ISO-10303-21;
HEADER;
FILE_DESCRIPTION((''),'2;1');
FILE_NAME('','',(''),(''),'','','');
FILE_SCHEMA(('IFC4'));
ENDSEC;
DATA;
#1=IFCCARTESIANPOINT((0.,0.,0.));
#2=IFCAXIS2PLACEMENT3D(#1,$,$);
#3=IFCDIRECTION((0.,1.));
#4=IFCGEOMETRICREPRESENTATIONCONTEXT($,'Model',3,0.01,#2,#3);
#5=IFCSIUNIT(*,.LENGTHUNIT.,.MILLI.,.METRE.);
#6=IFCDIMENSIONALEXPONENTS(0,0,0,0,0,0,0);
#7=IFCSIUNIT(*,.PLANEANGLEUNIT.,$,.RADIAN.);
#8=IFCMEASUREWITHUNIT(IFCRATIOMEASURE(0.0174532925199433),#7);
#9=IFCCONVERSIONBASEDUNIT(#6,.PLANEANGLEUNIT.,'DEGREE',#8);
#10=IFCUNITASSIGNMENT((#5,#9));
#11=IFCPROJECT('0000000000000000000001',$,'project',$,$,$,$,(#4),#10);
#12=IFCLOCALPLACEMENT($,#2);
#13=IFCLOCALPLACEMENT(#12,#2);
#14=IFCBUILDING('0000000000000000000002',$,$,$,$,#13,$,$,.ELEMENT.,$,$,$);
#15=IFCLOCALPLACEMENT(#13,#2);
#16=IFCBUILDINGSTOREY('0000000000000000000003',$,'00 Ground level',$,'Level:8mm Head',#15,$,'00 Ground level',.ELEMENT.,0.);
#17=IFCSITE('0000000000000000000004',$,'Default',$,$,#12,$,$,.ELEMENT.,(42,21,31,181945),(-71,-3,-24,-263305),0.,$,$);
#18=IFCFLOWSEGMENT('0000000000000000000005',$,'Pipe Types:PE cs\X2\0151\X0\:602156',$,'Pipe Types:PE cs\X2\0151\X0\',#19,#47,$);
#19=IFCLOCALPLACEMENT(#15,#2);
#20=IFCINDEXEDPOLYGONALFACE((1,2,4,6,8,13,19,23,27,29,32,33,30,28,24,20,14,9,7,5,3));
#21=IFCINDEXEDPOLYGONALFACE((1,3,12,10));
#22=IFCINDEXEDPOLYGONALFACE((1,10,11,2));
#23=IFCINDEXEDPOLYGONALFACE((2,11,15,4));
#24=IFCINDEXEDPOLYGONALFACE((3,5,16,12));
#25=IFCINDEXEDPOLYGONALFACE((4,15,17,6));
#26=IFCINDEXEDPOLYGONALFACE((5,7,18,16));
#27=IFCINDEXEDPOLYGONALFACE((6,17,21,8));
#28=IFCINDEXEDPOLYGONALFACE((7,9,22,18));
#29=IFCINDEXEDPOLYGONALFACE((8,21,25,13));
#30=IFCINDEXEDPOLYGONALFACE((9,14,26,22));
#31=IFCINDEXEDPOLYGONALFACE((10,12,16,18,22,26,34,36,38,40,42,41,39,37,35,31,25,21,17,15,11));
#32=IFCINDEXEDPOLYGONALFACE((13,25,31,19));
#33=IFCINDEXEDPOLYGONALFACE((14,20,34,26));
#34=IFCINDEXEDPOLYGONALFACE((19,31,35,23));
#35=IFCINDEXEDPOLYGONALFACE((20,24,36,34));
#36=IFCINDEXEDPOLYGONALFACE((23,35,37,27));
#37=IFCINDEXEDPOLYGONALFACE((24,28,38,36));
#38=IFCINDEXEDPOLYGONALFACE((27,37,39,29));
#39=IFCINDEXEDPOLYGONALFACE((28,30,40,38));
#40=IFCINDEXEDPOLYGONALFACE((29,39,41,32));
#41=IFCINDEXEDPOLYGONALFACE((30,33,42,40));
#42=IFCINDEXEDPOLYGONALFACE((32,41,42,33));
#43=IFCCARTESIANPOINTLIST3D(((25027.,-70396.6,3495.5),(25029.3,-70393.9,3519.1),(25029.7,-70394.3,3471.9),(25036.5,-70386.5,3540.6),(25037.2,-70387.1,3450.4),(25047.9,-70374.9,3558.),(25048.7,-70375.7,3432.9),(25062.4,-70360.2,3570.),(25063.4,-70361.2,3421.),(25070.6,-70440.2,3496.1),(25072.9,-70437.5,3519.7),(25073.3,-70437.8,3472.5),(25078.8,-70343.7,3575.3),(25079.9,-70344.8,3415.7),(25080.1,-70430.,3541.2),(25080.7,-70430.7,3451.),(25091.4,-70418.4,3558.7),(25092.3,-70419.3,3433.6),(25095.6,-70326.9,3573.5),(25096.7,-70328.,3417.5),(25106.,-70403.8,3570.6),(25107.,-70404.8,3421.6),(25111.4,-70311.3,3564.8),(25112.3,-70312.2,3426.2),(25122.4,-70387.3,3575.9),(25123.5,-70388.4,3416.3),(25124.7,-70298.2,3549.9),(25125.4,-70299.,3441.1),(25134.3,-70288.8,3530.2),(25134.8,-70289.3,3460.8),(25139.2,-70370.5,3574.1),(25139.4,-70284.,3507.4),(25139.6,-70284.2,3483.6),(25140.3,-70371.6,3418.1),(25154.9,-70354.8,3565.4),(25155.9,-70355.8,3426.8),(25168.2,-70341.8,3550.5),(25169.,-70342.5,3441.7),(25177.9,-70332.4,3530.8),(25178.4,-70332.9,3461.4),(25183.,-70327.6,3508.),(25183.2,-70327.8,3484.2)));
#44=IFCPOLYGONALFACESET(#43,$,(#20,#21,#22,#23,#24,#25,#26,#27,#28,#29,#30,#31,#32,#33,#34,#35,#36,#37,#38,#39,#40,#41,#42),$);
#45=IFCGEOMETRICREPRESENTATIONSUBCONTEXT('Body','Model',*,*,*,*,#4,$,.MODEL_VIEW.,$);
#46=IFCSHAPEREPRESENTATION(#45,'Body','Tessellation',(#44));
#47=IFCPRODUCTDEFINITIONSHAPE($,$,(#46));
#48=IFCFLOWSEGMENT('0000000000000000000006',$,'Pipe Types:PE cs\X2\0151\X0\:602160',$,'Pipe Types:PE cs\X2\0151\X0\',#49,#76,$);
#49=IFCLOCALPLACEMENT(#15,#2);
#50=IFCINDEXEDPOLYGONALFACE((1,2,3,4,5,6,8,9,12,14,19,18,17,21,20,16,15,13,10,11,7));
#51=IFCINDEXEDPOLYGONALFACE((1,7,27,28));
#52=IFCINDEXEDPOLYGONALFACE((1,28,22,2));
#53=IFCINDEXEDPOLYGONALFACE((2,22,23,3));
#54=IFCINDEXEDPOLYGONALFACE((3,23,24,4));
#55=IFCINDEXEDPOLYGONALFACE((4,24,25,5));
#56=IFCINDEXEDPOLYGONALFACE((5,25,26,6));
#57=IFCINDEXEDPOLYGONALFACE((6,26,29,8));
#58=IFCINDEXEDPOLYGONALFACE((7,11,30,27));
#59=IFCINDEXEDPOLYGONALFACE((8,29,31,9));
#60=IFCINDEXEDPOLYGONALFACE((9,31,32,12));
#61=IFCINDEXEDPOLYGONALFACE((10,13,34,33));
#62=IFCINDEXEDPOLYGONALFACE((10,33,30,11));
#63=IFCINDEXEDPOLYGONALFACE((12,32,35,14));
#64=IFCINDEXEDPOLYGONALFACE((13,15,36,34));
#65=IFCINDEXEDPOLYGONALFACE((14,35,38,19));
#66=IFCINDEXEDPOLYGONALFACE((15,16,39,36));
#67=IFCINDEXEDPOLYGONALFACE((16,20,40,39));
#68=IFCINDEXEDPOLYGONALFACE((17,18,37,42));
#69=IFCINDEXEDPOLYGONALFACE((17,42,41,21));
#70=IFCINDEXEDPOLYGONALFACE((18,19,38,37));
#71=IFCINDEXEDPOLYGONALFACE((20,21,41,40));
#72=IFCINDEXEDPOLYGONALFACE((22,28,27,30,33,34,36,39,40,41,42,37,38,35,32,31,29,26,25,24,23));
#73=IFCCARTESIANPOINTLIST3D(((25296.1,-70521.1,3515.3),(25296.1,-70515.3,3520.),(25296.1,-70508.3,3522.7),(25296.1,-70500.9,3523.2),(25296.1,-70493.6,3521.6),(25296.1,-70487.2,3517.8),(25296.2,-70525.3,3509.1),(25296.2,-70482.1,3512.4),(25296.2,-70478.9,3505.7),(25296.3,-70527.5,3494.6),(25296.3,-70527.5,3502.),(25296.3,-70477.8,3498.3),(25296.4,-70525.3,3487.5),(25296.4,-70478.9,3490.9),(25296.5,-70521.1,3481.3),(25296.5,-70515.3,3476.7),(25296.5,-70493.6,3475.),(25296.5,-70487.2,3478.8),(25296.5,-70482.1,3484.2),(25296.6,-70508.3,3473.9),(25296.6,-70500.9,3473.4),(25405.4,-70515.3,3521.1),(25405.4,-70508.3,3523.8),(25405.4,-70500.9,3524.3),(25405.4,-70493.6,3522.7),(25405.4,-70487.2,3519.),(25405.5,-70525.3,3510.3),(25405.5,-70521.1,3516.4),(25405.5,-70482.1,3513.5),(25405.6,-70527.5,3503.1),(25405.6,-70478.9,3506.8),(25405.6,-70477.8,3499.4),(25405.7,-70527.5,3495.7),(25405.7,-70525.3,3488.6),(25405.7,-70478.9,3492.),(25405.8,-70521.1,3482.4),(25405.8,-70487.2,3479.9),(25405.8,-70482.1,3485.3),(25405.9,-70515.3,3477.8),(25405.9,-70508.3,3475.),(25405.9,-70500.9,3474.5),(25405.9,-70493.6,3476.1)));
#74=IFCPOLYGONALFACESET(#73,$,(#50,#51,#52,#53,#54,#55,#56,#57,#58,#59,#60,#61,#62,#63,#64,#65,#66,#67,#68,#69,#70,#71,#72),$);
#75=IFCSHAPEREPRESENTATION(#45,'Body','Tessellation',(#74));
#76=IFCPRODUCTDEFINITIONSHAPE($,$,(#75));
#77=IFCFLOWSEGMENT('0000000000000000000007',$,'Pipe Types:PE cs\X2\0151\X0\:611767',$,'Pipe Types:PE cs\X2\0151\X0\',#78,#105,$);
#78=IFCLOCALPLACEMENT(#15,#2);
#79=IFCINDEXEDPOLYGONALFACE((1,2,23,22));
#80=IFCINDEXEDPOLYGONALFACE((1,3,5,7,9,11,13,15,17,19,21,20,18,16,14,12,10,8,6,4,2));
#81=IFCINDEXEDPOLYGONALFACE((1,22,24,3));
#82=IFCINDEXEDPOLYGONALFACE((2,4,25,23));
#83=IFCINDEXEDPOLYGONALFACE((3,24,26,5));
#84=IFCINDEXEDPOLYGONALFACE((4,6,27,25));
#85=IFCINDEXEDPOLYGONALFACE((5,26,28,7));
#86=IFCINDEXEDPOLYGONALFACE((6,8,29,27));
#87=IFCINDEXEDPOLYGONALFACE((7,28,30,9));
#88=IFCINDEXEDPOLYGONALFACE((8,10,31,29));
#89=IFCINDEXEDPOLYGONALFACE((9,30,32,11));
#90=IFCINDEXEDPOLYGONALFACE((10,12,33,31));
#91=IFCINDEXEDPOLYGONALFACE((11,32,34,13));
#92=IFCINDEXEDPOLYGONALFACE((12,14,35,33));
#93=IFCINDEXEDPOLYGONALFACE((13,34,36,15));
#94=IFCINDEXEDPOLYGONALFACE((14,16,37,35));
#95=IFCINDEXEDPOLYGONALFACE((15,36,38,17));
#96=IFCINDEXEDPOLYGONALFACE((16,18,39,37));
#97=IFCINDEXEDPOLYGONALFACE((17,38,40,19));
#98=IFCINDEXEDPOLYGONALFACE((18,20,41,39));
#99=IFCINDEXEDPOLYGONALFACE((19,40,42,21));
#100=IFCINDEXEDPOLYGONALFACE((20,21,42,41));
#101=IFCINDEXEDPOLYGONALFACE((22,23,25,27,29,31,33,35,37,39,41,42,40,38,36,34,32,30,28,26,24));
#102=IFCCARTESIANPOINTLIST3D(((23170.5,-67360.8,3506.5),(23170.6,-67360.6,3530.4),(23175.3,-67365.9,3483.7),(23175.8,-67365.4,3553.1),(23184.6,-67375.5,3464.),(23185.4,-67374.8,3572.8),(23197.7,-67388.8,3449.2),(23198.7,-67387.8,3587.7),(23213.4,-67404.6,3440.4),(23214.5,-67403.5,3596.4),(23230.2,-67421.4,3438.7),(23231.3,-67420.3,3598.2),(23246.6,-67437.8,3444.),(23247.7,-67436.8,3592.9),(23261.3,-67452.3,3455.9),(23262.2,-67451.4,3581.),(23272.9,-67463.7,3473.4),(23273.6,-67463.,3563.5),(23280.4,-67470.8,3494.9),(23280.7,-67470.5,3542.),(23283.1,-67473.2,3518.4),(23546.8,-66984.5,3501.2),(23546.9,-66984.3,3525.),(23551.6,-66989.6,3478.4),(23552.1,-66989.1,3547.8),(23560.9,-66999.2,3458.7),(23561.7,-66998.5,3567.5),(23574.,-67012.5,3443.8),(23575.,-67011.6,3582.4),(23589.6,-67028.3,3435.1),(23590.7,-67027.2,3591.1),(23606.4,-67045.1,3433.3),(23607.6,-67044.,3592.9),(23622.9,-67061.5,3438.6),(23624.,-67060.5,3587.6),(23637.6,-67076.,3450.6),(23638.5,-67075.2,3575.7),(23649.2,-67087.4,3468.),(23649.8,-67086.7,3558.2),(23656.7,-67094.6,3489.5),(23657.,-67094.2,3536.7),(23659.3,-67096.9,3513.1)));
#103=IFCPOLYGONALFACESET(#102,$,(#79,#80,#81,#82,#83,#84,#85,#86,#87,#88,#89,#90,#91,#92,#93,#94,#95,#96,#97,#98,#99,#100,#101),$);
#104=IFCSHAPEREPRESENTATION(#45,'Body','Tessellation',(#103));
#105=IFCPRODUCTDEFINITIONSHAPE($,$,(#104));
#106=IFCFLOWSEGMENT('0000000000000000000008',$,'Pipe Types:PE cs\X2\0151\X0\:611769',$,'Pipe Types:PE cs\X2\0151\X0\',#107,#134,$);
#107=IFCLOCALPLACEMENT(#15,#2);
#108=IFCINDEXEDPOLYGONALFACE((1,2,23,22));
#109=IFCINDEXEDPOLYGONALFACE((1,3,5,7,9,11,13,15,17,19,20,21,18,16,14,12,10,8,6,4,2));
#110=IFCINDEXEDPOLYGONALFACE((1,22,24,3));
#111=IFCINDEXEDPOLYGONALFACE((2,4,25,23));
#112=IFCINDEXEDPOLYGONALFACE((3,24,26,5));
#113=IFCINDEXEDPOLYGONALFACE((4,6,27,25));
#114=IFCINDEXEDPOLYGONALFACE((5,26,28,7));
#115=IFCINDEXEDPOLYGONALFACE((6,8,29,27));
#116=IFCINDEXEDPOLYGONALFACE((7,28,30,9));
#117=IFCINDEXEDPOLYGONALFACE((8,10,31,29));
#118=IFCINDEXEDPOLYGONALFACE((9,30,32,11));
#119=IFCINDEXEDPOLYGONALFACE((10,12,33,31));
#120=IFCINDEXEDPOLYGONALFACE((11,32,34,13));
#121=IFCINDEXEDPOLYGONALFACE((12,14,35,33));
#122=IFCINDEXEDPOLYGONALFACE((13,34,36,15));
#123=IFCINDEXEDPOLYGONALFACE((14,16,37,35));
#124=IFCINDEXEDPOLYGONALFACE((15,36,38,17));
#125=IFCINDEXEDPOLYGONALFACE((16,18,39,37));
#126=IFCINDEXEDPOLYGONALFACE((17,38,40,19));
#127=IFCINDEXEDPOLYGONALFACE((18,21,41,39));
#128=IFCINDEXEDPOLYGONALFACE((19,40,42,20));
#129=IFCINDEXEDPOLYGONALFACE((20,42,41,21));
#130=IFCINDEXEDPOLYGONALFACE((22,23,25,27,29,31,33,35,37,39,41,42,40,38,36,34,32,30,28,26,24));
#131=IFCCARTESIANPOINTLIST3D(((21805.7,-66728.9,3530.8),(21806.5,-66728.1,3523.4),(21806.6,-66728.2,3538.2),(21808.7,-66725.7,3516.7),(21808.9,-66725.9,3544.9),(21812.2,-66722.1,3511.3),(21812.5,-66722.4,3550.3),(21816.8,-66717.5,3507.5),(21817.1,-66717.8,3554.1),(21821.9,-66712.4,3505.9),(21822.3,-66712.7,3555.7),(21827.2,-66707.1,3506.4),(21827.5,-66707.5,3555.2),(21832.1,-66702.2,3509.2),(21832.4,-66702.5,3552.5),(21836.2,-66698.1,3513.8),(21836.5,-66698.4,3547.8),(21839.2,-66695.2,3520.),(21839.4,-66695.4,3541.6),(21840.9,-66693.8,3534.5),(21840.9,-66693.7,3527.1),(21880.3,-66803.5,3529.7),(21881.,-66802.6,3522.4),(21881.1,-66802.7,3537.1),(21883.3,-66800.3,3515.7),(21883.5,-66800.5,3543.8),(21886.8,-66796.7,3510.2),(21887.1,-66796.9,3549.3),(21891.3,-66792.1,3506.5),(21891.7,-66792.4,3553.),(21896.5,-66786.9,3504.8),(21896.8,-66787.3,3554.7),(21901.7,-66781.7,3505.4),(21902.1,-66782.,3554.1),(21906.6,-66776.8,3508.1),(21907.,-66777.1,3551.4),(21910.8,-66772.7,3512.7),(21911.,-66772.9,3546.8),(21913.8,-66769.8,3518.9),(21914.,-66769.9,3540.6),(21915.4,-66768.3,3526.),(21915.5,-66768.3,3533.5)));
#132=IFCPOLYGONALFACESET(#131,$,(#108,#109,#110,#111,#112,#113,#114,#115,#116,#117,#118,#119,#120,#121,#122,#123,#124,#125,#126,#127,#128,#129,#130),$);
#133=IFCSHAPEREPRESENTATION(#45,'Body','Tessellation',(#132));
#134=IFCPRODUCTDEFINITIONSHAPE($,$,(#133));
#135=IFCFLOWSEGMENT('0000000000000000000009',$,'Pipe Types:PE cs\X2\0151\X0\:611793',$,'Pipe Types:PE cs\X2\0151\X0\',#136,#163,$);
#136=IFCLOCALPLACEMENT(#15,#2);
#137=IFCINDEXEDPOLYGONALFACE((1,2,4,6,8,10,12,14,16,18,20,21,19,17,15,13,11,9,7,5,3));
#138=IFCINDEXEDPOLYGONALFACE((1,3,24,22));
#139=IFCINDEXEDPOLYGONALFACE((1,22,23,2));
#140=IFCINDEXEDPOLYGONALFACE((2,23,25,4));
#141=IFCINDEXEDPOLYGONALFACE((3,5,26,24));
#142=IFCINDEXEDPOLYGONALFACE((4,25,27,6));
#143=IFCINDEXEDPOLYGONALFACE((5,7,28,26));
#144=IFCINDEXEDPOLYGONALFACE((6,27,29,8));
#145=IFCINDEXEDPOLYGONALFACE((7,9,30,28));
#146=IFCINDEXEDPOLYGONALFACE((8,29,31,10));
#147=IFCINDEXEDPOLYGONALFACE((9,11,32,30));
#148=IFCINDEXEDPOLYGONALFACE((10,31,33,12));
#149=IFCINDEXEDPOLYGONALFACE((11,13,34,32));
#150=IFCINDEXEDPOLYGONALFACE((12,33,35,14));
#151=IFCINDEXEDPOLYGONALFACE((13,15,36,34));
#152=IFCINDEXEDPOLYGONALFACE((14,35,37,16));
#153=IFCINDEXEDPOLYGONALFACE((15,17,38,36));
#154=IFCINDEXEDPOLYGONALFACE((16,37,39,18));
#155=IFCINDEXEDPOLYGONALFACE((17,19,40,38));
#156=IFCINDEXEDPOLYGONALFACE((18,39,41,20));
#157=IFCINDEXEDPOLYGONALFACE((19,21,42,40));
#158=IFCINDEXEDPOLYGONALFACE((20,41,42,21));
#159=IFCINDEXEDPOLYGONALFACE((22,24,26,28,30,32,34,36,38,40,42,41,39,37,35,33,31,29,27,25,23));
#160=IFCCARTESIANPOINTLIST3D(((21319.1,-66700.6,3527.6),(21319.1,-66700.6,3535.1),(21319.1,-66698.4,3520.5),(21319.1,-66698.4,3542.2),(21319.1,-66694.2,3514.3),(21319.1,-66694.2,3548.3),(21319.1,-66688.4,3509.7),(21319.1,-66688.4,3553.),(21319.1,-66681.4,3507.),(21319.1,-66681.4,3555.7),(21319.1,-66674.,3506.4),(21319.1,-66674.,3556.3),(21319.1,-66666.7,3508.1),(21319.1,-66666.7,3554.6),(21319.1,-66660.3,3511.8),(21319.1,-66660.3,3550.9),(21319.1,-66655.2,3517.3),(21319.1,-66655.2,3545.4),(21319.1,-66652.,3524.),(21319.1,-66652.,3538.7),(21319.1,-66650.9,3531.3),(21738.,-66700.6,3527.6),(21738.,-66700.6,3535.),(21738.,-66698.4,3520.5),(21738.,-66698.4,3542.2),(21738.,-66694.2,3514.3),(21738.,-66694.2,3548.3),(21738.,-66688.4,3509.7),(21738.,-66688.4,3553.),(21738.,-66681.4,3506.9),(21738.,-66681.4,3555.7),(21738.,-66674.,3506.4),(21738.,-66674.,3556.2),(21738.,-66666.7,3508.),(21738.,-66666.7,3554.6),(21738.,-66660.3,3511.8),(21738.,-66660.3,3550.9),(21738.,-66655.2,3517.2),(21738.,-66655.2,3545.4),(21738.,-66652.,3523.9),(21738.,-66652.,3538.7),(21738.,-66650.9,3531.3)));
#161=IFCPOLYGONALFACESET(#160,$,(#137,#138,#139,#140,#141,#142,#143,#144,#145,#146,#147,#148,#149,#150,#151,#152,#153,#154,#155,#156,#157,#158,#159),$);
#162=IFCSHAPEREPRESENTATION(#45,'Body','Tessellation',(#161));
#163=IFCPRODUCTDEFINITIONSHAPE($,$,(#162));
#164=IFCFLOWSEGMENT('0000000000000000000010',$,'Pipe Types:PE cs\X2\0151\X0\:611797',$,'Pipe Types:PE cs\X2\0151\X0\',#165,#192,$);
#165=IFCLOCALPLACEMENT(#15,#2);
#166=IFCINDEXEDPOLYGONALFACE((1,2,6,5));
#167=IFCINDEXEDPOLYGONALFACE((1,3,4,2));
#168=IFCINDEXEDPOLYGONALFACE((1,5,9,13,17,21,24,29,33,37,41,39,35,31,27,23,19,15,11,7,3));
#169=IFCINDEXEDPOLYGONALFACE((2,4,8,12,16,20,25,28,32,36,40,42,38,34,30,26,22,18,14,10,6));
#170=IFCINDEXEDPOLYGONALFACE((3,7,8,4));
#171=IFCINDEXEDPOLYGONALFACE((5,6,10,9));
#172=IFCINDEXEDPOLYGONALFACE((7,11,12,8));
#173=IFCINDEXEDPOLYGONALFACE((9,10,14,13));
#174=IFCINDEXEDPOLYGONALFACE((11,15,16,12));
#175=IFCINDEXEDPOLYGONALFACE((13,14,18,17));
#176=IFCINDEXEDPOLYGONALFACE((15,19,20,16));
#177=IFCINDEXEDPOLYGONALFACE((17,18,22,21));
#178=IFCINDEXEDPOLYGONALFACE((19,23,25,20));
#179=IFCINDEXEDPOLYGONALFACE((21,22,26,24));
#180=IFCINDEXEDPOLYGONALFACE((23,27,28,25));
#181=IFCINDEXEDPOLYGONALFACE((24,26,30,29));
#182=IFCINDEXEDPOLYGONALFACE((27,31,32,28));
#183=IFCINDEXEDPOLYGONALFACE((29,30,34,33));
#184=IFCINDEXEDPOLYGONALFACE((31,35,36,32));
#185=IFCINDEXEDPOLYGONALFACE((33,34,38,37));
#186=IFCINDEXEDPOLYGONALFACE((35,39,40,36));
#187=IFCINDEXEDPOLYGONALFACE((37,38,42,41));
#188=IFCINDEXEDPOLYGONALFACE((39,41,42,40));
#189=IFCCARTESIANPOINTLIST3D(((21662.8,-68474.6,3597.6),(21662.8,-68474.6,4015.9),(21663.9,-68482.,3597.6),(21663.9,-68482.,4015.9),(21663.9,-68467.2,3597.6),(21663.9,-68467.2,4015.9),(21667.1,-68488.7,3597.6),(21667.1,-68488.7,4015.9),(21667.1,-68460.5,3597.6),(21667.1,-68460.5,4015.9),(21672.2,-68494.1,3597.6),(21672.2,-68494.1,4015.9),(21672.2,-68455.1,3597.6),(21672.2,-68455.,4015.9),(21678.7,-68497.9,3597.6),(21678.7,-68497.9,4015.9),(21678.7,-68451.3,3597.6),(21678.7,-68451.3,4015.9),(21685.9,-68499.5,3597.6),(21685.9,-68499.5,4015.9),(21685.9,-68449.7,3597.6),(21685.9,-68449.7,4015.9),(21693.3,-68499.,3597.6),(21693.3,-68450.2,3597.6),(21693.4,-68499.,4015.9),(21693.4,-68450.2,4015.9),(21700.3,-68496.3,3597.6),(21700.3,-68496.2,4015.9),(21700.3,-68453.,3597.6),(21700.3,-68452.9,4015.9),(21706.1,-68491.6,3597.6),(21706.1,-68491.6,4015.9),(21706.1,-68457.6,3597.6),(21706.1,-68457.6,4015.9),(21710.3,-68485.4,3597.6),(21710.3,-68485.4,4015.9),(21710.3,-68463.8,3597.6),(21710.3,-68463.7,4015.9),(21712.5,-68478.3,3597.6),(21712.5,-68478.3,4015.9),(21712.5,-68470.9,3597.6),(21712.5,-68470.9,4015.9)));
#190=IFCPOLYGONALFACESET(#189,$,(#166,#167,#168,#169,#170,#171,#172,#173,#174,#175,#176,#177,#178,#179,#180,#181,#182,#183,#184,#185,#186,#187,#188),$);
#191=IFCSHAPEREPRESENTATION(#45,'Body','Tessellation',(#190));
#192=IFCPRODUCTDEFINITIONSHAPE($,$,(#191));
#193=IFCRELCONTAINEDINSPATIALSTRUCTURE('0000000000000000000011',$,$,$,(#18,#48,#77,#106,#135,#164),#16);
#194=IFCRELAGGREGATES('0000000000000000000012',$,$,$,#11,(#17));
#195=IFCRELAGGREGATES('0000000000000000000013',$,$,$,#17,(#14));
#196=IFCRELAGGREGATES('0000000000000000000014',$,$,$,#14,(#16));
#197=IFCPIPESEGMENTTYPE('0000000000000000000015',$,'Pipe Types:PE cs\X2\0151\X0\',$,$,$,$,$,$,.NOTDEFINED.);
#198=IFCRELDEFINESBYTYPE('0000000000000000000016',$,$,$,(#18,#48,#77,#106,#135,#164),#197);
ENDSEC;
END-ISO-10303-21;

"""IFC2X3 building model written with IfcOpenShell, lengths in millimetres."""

from ifc_helpers import new_model, entity, si_unit, converted_unit, direction, frame, frame_2d, origin, origin_2d_with_axis, place, context, subcontext, project, spatial, circle, extrude, type_object, element, save


model = new_model("IFC2X3")

# Units and contexts
model_context = context("Model", 3, precision=0.01, world=origin(), true_north=direction((0.0, 1.0)))
body_context = subcontext(model_context, "Body", "Model", "MODEL_VIEW")
ifc_project = project(units=[si_unit("LENGTHUNIT", "METRE", prefix="MILLI"), converted_unit("PLANEANGLEUNIT", "DEGREE", entity("IfcRatioMeasure", 0.0174532925199433), si_unit("PLANEANGLEUNIT", "RADIAN"), dimensions=[0, 0, 0, 0, 0, 0, 0])], contexts=[model_context])

# Site, building, storey
site_placement = place(None, origin())
site = spatial("IfcSite", under=ifc_project, at=site_placement, Name="Default", CompositionType="ELEMENT", RefLatitude=(42, 21, 31, 181945), RefLongitude=(-71, -3, -24, -263305), RefElevation=0.0)
building_placement = place(site_placement, origin())
building = spatial("IfcBuilding", under=site, at=building_placement, CompositionType="ELEMENT")
storey_placement = place(building_placement, origin())
storey = spatial("IfcBuildingStorey", under=building, at=storey_placement, Name="00 Ground level", ObjectType="Level:8mm Head", LongName="00 Ground level", CompositionType="ELEMENT", Elevation=0.0)

# Flow segments
pipe_segment_type = type_object("IfcPipeSegmentType", Name="Pipe Types:PE cső", PredefinedType="NOTDEFINED")
flow_segment_1_placement = place(storey_placement, frame((25025.4, -70441.8, 3413.9)))
element("IfcFlowSegment", 1, at=flow_segment_1_placement, inside=storey, type_object=pipe_segment_type, Name="Pipe Types:PE cső:602156", ObjectType="Pipe Types:PE cső", context=body_context, shape_type="SweptSolid", body=[
    extrude(circle(Radius=80.0, at=origin_2d_with_axis()), frame((58.2, 101.7, 81.6), z_axis=(0.707071, -0.707071, 0.010046), x_axis=(-0.707107, -0.707107, 0.0)), (0.0, 0.0, 1.0), 61.6),
])
flow_segment_2_placement = place(storey_placement, frame((25294.5, -70529.4, 3471.7)))
element("IfcFlowSegment", 2, at=flow_segment_2_placement, inside=storey, type_object=pipe_segment_type, Name="Pipe Types:PE cső:602160", ObjectType="Pipe Types:PE cső", context=body_context, shape_type="SweptSolid", body=[
    extrude(circle(Radius=25.0, at=frame_2d((0.0, 0.0), x_axis=(1.0, 0.0))), frame((1.9, 26.6, 26.6), z_axis=(0.999948, -0.000032, 0.010203), x_axis=(0.000032, 1.0, 0.0)), (0.0, 0.0, 1.0), 109.3),
])
flow_segment_3_placement = place(storey_placement, frame((23168.3, -67474.8, 3431.5)))
element("IfcFlowSegment", 3, at=flow_segment_3_placement, inside=storey, type_object=pipe_segment_type, Name="Pipe Types:PE cső:611767", ObjectType="Pipe Types:PE cső", context=body_context, shape_type="SweptSolid", body=[
    extrude(circle(Radius=80.0, at=origin_2d_with_axis()), frame((58.2, 58.2, 86.9), z_axis=(0.707071, 0.707071, -0.01), x_axis=(0.707107, -0.707107, 0.0)), (0.0, 0.0, 1.0), 532.2),
])
flow_segment_4_placement = place(storey_placement, frame((21804.1, -66805.1, 3503.2)))
element("IfcFlowSegment", 4, at=flow_segment_4_placement, inside=storey, type_object=pipe_segment_type, Name="Pipe Types:PE cső:611769", ObjectType="Pipe Types:PE cső", context=body_context, shape_type="SweptSolid", body=[
    extrude(circle(Radius=25.0, at=frame_2d((0.0, 0.0), x_axis=(1.0, 0.0))), frame((19.3, 93.8, 27.6), z_axis=(0.707071, -0.707071, -0.01), x_axis=(-0.707107, -0.707107, 0.0)), (0.0, 0.0, 1.0), 105.5),
])
flow_segment_5_placement = place(storey_placement, frame((21319.1, -66702.5, 3504.7)))
element("IfcFlowSegment", 5, at=flow_segment_5_placement, inside=storey, type_object=pipe_segment_type, Name="Pipe Types:PE cső:611793", ObjectType="Pipe Types:PE cső", context=body_context, shape_type="SweptSolid", body=[
    extrude(circle(Radius=25.0, at=origin_2d_with_axis()), frame((0.0, 26.6, 26.6), z_axis=(1.0, 0.0, -0.000085), x_axis=(0.0, 1.0, 0.0)), (0.0, 0.0, 1.0), 418.9),
])
flow_segment_6_placement = place(storey_placement, frame((21661.2, -68501.2, 3597.6)))
element("IfcFlowSegment", 6, at=flow_segment_6_placement, inside=storey, type_object=pipe_segment_type, Name="Pipe Types:PE cső:611797", ObjectType="Pipe Types:PE cső", context=body_context, shape_type="SweptSolid", body=[
    extrude(circle(Radius=25.0, at=frame_2d((0.0, 0.0), x_axis=(1.0, 0.0))), frame((26.6, 26.6, 0.0), z_axis=(0.000019, 0.000019, 1.0), x_axis=(-1.0, 0.0, 0.000019)), (0.0, 0.0, 1.0), 418.2),
])

save(model, "model.ifc")
